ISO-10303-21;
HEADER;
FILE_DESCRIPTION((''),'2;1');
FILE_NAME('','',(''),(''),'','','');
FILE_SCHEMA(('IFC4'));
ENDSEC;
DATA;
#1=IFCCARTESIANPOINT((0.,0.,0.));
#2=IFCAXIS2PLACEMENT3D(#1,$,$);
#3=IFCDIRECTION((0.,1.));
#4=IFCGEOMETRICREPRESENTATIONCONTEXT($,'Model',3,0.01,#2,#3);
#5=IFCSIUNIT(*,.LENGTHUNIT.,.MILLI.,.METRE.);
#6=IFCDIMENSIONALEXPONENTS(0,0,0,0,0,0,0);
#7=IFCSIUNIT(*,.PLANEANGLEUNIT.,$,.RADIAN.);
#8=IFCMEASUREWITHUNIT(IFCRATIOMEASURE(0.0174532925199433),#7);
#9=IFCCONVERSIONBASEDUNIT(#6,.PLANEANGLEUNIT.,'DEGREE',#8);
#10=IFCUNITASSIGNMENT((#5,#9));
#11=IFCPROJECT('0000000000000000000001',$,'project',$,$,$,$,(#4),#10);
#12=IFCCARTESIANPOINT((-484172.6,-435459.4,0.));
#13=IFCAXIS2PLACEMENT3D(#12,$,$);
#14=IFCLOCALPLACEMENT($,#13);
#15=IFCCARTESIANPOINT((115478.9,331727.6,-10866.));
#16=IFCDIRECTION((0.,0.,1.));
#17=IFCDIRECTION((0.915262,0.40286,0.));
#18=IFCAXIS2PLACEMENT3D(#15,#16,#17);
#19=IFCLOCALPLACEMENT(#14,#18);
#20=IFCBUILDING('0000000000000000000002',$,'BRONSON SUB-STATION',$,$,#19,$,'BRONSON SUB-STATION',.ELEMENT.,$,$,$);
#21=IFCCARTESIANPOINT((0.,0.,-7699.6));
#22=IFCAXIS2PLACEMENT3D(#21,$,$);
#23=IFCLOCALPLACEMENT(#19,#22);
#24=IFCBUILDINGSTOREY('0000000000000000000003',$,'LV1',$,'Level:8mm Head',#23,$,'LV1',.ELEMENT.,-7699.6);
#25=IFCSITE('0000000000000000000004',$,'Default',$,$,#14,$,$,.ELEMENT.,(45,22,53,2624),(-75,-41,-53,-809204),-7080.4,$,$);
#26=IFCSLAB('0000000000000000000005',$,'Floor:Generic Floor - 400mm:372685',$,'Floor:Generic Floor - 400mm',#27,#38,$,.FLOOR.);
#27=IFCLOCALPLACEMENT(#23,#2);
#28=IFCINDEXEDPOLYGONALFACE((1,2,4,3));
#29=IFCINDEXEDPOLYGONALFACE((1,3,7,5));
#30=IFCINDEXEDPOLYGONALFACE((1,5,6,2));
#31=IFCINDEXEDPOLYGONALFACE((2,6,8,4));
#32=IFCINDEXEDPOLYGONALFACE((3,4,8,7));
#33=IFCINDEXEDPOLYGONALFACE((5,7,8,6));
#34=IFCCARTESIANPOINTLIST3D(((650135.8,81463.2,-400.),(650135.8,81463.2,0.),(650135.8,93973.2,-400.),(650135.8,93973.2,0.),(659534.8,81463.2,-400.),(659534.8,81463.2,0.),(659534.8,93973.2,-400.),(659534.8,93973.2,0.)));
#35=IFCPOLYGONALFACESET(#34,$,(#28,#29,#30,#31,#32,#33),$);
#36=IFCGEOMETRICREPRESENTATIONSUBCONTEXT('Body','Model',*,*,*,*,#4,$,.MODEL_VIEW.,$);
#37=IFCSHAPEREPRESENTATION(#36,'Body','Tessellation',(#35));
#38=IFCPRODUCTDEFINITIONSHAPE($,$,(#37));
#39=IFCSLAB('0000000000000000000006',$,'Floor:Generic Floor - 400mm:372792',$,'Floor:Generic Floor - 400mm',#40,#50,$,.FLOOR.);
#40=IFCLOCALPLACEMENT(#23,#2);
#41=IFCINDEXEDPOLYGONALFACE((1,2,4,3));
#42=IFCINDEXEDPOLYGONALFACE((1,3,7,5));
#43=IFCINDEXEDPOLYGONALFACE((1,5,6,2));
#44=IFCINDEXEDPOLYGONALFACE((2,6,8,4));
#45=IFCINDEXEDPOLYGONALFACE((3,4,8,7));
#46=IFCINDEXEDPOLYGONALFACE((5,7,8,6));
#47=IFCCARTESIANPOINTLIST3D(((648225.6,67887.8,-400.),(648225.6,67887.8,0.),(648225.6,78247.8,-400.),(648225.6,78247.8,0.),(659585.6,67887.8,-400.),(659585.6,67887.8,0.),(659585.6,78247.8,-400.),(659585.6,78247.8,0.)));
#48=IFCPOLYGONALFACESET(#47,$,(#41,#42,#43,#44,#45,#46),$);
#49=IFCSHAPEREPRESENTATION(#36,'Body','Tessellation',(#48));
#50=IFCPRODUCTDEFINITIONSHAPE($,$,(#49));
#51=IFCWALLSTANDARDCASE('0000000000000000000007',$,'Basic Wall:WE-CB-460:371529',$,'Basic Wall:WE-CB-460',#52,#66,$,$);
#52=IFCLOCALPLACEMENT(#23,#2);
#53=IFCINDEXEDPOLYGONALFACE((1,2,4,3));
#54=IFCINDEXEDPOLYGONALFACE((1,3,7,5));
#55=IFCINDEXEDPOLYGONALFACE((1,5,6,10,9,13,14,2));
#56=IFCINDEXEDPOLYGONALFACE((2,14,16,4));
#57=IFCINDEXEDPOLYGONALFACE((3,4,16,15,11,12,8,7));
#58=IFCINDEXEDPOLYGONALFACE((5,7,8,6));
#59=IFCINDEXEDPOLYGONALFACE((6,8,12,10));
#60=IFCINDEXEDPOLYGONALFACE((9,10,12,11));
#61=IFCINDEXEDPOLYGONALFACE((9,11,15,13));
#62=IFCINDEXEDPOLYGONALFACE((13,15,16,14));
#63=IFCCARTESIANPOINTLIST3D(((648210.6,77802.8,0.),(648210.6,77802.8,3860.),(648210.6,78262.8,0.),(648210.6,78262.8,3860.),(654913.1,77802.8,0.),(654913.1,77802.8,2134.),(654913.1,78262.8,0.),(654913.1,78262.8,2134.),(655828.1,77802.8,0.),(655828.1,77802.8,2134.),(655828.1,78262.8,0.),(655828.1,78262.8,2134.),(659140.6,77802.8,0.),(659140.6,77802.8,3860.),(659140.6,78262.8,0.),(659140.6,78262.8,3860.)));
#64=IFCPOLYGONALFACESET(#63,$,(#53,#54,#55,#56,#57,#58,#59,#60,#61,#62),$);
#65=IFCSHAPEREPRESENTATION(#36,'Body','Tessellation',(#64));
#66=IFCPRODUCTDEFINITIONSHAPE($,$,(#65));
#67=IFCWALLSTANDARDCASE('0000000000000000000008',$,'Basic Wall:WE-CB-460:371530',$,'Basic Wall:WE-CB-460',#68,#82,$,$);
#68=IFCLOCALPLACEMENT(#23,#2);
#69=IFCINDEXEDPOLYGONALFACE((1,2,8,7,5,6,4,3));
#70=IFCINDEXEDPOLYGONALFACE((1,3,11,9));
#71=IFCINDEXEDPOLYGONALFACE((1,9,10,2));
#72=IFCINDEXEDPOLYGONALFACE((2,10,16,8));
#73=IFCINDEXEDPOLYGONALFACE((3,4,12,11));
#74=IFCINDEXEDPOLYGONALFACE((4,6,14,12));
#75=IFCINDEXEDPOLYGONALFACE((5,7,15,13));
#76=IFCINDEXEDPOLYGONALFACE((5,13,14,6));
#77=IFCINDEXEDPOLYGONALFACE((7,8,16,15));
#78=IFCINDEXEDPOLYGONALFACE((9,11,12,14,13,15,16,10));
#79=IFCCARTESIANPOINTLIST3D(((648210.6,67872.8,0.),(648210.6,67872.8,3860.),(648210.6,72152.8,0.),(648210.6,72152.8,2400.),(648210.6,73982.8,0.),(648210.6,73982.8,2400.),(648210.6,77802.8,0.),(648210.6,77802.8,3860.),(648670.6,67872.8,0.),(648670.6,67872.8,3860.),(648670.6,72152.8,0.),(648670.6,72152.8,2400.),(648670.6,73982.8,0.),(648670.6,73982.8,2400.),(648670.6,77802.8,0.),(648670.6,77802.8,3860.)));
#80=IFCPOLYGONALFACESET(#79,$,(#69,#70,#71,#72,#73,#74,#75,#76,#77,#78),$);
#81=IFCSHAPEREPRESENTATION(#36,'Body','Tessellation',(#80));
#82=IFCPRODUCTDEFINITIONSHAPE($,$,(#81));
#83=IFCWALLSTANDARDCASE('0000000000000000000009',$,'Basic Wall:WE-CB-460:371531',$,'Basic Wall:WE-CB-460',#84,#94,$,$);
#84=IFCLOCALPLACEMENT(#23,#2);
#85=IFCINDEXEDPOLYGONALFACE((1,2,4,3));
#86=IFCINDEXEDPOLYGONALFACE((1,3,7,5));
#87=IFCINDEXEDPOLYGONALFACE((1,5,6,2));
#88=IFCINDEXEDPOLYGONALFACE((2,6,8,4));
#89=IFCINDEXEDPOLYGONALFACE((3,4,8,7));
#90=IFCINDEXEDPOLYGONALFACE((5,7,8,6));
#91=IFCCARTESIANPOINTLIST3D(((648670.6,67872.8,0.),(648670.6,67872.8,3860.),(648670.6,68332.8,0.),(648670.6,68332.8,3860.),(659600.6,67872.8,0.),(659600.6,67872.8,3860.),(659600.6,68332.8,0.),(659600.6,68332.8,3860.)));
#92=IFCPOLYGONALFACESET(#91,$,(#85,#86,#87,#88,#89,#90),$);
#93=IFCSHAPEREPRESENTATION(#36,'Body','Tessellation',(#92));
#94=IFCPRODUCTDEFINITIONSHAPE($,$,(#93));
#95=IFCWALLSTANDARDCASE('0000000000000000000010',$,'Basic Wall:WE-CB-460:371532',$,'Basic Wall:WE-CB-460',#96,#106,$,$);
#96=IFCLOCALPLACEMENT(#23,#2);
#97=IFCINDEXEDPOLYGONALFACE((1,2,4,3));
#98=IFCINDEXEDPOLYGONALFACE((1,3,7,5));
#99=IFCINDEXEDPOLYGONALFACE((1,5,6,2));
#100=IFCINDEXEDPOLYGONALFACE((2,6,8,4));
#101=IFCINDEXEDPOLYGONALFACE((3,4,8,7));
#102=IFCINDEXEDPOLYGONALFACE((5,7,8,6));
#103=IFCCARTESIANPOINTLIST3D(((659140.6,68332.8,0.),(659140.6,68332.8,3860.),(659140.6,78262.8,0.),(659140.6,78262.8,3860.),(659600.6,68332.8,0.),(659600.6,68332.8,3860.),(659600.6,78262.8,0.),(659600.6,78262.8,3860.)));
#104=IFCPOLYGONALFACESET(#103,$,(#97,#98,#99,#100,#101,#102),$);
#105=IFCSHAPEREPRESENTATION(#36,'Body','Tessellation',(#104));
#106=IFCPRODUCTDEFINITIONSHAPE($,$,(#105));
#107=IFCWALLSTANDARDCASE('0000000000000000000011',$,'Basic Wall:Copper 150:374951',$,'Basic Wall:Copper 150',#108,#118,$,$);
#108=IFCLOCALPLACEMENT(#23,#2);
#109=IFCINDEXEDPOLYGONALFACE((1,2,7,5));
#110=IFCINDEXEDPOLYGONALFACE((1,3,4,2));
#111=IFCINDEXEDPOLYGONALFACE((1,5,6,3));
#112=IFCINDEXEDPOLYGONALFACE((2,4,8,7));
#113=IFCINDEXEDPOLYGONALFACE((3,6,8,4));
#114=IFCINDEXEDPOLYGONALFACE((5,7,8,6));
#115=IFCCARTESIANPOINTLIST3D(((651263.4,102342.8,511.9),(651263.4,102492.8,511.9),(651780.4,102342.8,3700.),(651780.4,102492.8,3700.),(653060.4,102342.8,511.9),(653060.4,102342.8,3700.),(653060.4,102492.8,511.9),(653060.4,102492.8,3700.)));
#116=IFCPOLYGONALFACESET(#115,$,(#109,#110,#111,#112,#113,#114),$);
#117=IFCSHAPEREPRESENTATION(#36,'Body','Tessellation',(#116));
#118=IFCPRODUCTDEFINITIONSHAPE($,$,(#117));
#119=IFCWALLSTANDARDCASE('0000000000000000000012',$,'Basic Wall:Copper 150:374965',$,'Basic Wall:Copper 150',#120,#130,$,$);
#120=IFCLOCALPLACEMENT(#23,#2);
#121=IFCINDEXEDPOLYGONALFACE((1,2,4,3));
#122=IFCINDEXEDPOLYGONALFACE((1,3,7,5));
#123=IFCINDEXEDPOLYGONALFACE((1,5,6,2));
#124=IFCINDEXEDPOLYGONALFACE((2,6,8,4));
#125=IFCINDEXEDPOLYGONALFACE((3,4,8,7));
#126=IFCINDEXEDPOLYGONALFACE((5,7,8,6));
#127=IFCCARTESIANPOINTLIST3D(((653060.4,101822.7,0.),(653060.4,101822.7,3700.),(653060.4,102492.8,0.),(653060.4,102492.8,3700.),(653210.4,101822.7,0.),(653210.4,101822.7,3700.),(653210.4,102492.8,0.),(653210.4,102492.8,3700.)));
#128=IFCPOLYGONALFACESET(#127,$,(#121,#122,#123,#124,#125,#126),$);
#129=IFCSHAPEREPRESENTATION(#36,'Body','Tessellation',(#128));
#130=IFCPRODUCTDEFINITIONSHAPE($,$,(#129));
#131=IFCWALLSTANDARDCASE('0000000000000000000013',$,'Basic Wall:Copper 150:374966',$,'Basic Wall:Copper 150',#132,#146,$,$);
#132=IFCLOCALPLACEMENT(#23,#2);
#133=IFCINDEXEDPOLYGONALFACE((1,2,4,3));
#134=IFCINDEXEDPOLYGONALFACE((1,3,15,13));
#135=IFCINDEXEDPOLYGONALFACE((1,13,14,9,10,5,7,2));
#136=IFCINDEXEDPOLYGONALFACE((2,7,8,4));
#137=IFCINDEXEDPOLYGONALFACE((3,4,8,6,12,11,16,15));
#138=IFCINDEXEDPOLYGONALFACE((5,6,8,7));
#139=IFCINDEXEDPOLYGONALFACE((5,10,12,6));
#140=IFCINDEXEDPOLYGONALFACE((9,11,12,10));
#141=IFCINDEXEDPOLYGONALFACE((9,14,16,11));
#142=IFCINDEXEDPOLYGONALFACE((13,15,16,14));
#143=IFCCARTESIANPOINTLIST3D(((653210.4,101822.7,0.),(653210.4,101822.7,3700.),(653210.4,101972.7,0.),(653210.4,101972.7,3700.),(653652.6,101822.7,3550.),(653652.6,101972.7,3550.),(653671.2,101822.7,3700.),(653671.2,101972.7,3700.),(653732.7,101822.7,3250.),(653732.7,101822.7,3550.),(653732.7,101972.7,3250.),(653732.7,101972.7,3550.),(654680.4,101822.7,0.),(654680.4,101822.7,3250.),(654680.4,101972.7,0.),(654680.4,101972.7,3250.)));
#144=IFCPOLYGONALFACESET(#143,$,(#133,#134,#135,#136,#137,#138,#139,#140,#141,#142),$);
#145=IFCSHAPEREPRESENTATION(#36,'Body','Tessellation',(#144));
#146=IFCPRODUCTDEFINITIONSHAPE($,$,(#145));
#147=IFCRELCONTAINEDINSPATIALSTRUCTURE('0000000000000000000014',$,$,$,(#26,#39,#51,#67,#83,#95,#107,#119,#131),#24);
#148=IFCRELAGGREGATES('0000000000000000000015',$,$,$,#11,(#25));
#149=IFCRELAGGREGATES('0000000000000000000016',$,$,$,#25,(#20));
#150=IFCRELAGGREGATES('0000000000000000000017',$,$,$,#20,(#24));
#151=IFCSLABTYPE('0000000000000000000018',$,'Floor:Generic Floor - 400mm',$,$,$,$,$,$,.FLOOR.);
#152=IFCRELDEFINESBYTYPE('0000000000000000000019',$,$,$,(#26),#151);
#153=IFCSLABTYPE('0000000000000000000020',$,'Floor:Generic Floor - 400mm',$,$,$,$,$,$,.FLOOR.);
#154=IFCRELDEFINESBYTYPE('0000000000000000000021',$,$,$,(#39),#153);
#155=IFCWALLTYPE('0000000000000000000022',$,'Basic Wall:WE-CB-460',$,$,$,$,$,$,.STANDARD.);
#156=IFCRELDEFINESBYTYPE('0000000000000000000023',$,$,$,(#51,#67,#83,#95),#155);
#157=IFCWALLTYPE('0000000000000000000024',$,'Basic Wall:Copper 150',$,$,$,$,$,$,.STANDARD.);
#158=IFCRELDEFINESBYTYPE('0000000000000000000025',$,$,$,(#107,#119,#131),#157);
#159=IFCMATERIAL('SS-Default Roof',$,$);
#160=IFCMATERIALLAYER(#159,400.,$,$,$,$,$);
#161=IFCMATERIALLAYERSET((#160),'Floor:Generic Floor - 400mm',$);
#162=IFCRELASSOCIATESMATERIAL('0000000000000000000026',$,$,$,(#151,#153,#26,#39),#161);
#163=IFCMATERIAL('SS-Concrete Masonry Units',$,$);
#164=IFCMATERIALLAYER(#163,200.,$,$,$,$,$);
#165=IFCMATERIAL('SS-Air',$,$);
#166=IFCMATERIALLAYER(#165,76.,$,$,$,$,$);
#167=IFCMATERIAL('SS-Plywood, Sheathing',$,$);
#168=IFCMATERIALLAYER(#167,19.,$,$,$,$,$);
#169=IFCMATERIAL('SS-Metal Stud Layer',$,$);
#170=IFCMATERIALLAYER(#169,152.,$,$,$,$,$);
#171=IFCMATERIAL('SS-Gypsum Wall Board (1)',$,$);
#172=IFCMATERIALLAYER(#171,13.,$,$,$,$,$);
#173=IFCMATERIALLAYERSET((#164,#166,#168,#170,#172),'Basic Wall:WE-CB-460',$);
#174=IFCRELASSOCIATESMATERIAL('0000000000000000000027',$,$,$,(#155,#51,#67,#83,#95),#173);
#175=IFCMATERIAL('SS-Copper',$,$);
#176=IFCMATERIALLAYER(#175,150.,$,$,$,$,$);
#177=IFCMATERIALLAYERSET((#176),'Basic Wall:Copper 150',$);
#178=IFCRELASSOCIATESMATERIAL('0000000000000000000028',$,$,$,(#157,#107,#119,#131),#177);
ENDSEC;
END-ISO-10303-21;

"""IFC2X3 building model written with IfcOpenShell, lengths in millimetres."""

from ifc_helpers import new_model, entity, si_unit, converted_unit, direction, frame, frame_2d, origin, origin_2d_with_axis, place, context, subcontext, project, spatial, polyline, rectangle, outline, extrude, clip, bounded_halfspace, material, layer, layer_set, layer_usage, type_object, element, save


model = new_model("IFC2X3")

# Units and contexts
model_context = context("Model", 3, precision=0.01, world=origin(), true_north=direction((0.0, 1.0)))
body_context = subcontext(model_context, "Body", "Model", "MODEL_VIEW")
ifc_project = project(units=[si_unit("LENGTHUNIT", "METRE", prefix="MILLI"), converted_unit("PLANEANGLEUNIT", "DEGREE", entity("IfcRatioMeasure", 0.0174532925199433), si_unit("PLANEANGLEUNIT", "RADIAN"), dimensions=[0, 0, 0, 0, 0, 0, 0])], contexts=[model_context])

# Site, building, storey
site_placement = place(None, frame((-484172.6, -435459.4, 0.0)))
site = spatial("IfcSite", under=ifc_project, at=site_placement, Name="Default", CompositionType="ELEMENT", RefLatitude=(45, 22, 53, 2624), RefLongitude=(-75, -41, -53, -809204), RefElevation=-7080.4)
building_placement = place(site_placement, frame((115478.9, 331727.6, -10866.0), z_axis=(0.0, 0.0, 1.0), x_axis=(0.915262, 0.40286, 0.0)))
building = spatial("IfcBuilding", under=site, at=building_placement, Name="BRONSON SUB-STATION", LongName="BRONSON SUB-STATION", CompositionType="ELEMENT")
storey_placement = place(building_placement, frame((0.0, 0.0, -7699.6)))
storey = spatial("IfcBuildingStorey", under=building, at=storey_placement, Name="LV1", ObjectType="Level:8mm Head", LongName="LV1", CompositionType="ELEMENT", Elevation=-7699.6)

# Slabs
ifc_material_1 = material(Name="SS-Default Roof")
ifc_layer_1 = layer(ifc_material_1, 400.0)
ifc_layer_set_1 = layer_set([ifc_layer_1], Name="Floor:Generic Floor - 400mm")
ifc_layer_usage_1 = layer_usage(ifc_layer_set_1, "AXIS3", "POSITIVE", 0.0)
slab_type_1 = type_object("IfcSlabType", Name="Floor:Generic Floor - 400mm", PredefinedType="FLOOR", material=ifc_layer_set_1)
slab_1_placement = place(storey_placement, origin())
element("IfcSlab", 1, at=slab_1_placement, inside=storey, type_object=slab_type_1, material=ifc_layer_usage_1, Name="Floor:Generic Floor - 400mm:372685", ObjectType="Floor:Generic Floor - 400mm", PredefinedType="FLOOR", context=body_context, shape_type="SweptSolid", body=[
    extrude(rectangle(XDim=12510.0, YDim=9399.0, at=origin_2d_with_axis()), frame((654835.3, 87718.2, 0.0), z_axis=(0.0, 0.0, -1.0), x_axis=(0.0, 1.0, 0.0)), (0.0, 0.0, 1.0), 400.0),
])
ifc_layer_usage_2 = layer_usage(ifc_layer_set_1, "AXIS3", "POSITIVE", 0.0)
slab_type_2 = type_object("IfcSlabType", Name="Floor:Generic Floor - 400mm", PredefinedType="FLOOR", material=ifc_layer_set_1)
slab_2_placement = place(storey_placement, origin())
element("IfcSlab", 2, at=slab_2_placement, inside=storey, type_object=slab_type_2, material=ifc_layer_usage_2, Name="Floor:Generic Floor - 400mm:372792", ObjectType="Floor:Generic Floor - 400mm", PredefinedType="FLOOR", context=body_context, shape_type="SweptSolid", body=[
    extrude(rectangle(XDim=10360.0, YDim=11360.0, at=frame_2d((0.0, 0.0), x_axis=(1.0, 0.0))), frame((653905.6, 73067.8, 0.0), z_axis=(0.0, 0.0, -1.0), x_axis=(0.0, 1.0, 0.0)), (0.0, 0.0, 1.0), 400.0),
])

# Walls, openings
ifc_material_2 = material(Name="SS-Concrete Masonry Units")
ifc_layer_2 = layer(ifc_material_2, 200.0)
ifc_material_3 = material(Name="SS-Air")
ifc_layer_3 = layer(ifc_material_3, 76.0)
ifc_material_4 = material(Name="SS-Plywood, Sheathing")
ifc_layer_4 = layer(ifc_material_4, 19.0)
ifc_material_5 = material(Name="SS-Metal Stud Layer")
ifc_layer_5 = layer(ifc_material_5, 152.0)
ifc_material_6 = material(Name="SS-Gypsum Wall Board (1)")
ifc_layer_6 = layer(ifc_material_6, 13.0)
ifc_layer_set_2 = layer_set([ifc_layer_2, ifc_layer_3, ifc_layer_4, ifc_layer_5, ifc_layer_6], Name="Basic Wall:WE-CB-460")
ifc_layer_usage_3 = layer_usage(ifc_layer_set_2, "AXIS2", "NEGATIVE", 230.0)
wall_type_1 = type_object("IfcWallType", Name="Basic Wall:WE-CB-460", PredefinedType="STANDARD", material=ifc_layer_set_2)
wall_1_placement = place(storey_placement, frame((648210.6, 78032.8, 0.0)))
wall_1 = element("IfcWallStandardCase", 3, at=wall_1_placement, inside=storey, type_object=wall_type_1, material=ifc_layer_usage_3, Name="Basic Wall:WE-CB-460:371529", ObjectType="Basic Wall:WE-CB-460", context=body_context, shape_type="Clipping", body=[
    clip(extrude(rectangle(XDim=10930.0, YDim=460.0, at=frame_2d((5465.0, 0.0), x_axis=(-1.0, 0.0))), origin(), (0.0, 0.0, 1.0), 3860.0), bounded_halfspace(frame((0.0, -230.0, 3860.0)), False, frame((0.0, -230.0, 3860.0)), polyline([(0.0, 0.0), (460.0, 0.0), (10930.0, 0.0), (10930.0, 460.0), (0.0, 460.0), (0.0, 0.0)]))),
])
opening_1_placement = place(wall_1_placement, origin())
element("IfcOpeningElement", 4, at=opening_1_placement, cuts=wall_1, ObjectType="Opening", context=body_context, shape_type="SweptSolid", body=[
    extrude(rectangle(XDim=2134.0, YDim=915.0, at=frame_2d((0.0, 0.0), x_axis=(1.0, 0.0))), frame((7160.0, -1754.0, 1067.0), z_axis=(0.0, 1.0, 0.0), x_axis=(0.0, 0.0, 1.0)), (0.0, 0.0, 1.0), 3048.0),
])
ifc_layer_usage_4 = layer_usage(ifc_layer_set_2, "AXIS2", "NEGATIVE", 230.0)
wall_2_placement = place(storey_placement, frame((648440.6, 67872.8, 0.0), z_axis=(0.0, 0.0, 1.0), x_axis=(0.0, 1.0, 0.0)))
wall_2 = element("IfcWallStandardCase", 5, at=wall_2_placement, inside=storey, type_object=wall_type_1, material=ifc_layer_usage_4, Name="Basic Wall:WE-CB-460:371530", ObjectType="Basic Wall:WE-CB-460", context=body_context, shape_type="Clipping", body=[
    clip(extrude(rectangle(XDim=9930.0, YDim=460.0, at=frame_2d((4965.0, 0.0), x_axis=(-1.0, 0.0))), origin(), (0.0, 0.0, 1.0), 3860.0), bounded_halfspace(frame((0.0, -230.0, 3860.0), z_axis=(0.0, 0.0, 1.0), x_axis=(0.0, -1.0, 0.0)), False, frame((0.0, -230.0, 3860.0)), polyline([(0.0, 0.0), (460.0, 0.0), (9930.0, 0.0), (9930.0, 460.0), (0.0, 460.0), (0.0, 0.0)]))),
])
opening_2_placement = place(wall_2_placement, origin())
element("IfcOpeningElement", 6, at=opening_2_placement, cuts=wall_2, ObjectType="Opening", context=body_context, shape_type="SweptSolid", body=[
    extrude(rectangle(XDim=2400.0, YDim=1830.0, at=frame_2d((0.0, 0.0), x_axis=(1.0, 0.0))), frame((5195.0, -1754.0, 1200.0), z_axis=(0.0, 1.0, 0.0), x_axis=(0.0, 0.0, 1.0)), (0.0, 0.0, 1.0), 3048.0),
])

# Walls
ifc_layer_usage_5 = layer_usage(ifc_layer_set_2, "AXIS2", "NEGATIVE", 230.0)
wall_3_placement = place(storey_placement, frame((659600.6, 68102.8, 0.0), z_axis=(0.0, 0.0, 1.0), x_axis=(-1.0, 0.0, 0.0)))
element("IfcWallStandardCase", 7, at=wall_3_placement, inside=storey, type_object=wall_type_1, material=ifc_layer_usage_5, Name="Basic Wall:WE-CB-460:371531", ObjectType="Basic Wall:WE-CB-460", context=body_context, shape_type="Clipping", body=[
    clip(extrude(rectangle(XDim=10930.0, YDim=460.0, at=frame_2d((5465.0, 0.0), x_axis=(-1.0, 0.0))), origin(), (0.0, 0.0, 1.0), 3860.0), bounded_halfspace(frame((0.0, -230.0, 3860.0), z_axis=(0.0, 0.0, 1.0), x_axis=(-1.0, 0.0, 0.0)), False, frame((0.0, -230.0, 3860.0)), polyline([(0.0, 0.0), (460.0, 0.0), (10930.0, 0.0), (10930.0, 460.0), (0.0, 460.0), (0.0, 0.0)]))),
])
ifc_layer_usage_6 = layer_usage(ifc_layer_set_2, "AXIS2", "NEGATIVE", 230.0)
wall_4_placement = place(storey_placement, frame((659370.6, 78262.8, 0.0), z_axis=(0.0, 0.0, 1.0), x_axis=(0.0, -1.0, 0.0)))
element("IfcWallStandardCase", 8, at=wall_4_placement, inside=storey, type_object=wall_type_1, material=ifc_layer_usage_6, Name="Basic Wall:WE-CB-460:371532", ObjectType="Basic Wall:WE-CB-460", context=body_context, shape_type="Clipping", body=[
    clip(extrude(rectangle(XDim=9930.0, YDim=460.0, at=frame_2d((4965.0, 0.0), x_axis=(-1.0, 0.0))), origin(), (0.0, 0.0, 1.0), 3860.0), bounded_halfspace(frame((0.0, -230.0, 3860.0), z_axis=(0.0, 0.0, 1.0), x_axis=(0.0, 1.0, 0.0)), False, frame((0.0, -230.0, 3860.0)), polyline([(0.0, 0.0), (460.0, 0.0), (9930.0, 0.0), (9930.0, 460.0), (0.0, 460.0), (0.0, 0.0)]))),
])
ifc_material_7 = material(Name="SS-Copper")
ifc_layer_7 = layer(ifc_material_7, 150.0)
ifc_layer_set_3 = layer_set([ifc_layer_7], Name="Basic Wall:Copper 150")
ifc_layer_usage_7 = layer_usage(ifc_layer_set_3, "AXIS2", "POSITIVE", -75.0)
wall_type_2 = type_object("IfcWallType", Name="Basic Wall:Copper 150", PredefinedType="STANDARD", material=ifc_layer_set_3)
wall_5_placement = place(storey_placement, frame((651263.4, 102417.8, 511.9)))
element("IfcWallStandardCase", 9, at=wall_5_placement, inside=storey, type_object=wall_type_2, material=ifc_layer_usage_7, Name="Basic Wall:Copper 150:374951", ObjectType="Basic Wall:Copper 150", context=body_context, shape_type="Clipping", body=[
    clip(extrude(rectangle(XDim=1797.0, YDim=150.0, at=frame_2d((898.5, 0.0), x_axis=(-1.0, 0.0))), origin(), (0.0, 0.0, 1.0), 3188.1), bounded_halfspace(frame((0.0, -75.0, 0.0), z_axis=(-0.987105, 0.0, 0.160071), x_axis=(0.0, -1.0, 0.0)), False, frame((0.0, -75.0, 0.0), z_axis=(-0.987105, 0.0, 0.160071), x_axis=(0.0, -1.0, 0.0)), polyline([(0.0, 0.0), (0.0, 3229.7), (-150.0, 3229.7), (-150.0, 0.0), (0.0, 0.0)]))),
])
ifc_layer_usage_8 = layer_usage(ifc_layer_set_3, "AXIS2", "POSITIVE", -75.0)
wall_6_placement = place(storey_placement, frame((653135.4, 102492.8, 0.0), z_axis=(0.0, 0.0, 1.0), x_axis=(0.0, -1.0, 0.0)))
element("IfcWallStandardCase", 10, at=wall_6_placement, inside=storey, type_object=wall_type_2, material=ifc_layer_usage_8, Name="Basic Wall:Copper 150:374965", ObjectType="Basic Wall:Copper 150", context=body_context, shape_type="SweptSolid", body=[
    extrude(rectangle(XDim=670.2, YDim=150.0, at=frame_2d((335.1, 0.0), x_axis=(-1.0, 0.0))), origin(), (0.0, 0.0, 1.0), 3700.0),
])

# Wall, opening
ifc_layer_usage_9 = layer_usage(ifc_layer_set_3, "AXIS2", "POSITIVE", -75.0)
wall_7_placement = place(storey_placement, frame((653210.4, 101897.7, 0.0)))
wall_7 = element("IfcWallStandardCase", 11, at=wall_7_placement, inside=storey, type_object=wall_type_2, material=ifc_layer_usage_9, Name="Basic Wall:Copper 150:374966", ObjectType="Basic Wall:Copper 150", context=body_context, shape_type="Clipping", body=[
    clip(clip(extrude(rectangle(XDim=1470.0, YDim=150.0, at=frame_2d((735.0, 0.0), x_axis=(-1.0, 0.0))), origin(), (0.0, 0.0, 1.0), 3700.0), bounded_halfspace(frame((522.3, 75.0, 3250.0)), False, frame((522.3, 75.0, 3250.0)), polyline([(0.0, 0.0), (0.0, -150.0), (947.7, -150.0), (947.7, 0.0), (0.0, 0.0)]))), bounded_halfspace(frame((522.3, -75.0, 3250.0), z_axis=(-1.0, 0.0, 0.0), x_axis=(0.0, -1.0, 0.0)), True, frame((522.3, -75.0, 3250.0), z_axis=(-1.0, 0.0, 0.0), x_axis=(0.0, -1.0, 0.0)), polyline([(0.0, 0.0), (0.0, 300.0), (-150.0, 300.0), (-150.0, 0.0), (0.0, 0.0)]))),
])
opening_3_placement = place(wall_7_placement, origin())
element("IfcOpeningElement", 12, at=opening_3_placement, cuts=wall_7, ObjectType="Opening", context=body_context, shape_type="SweptSolid", body=[
    extrude(outline(polyline([(-75.0, -484.3), (75.0, -484.3), (75.0, 474.9), (-75.0, 493.6), (-75.0, -484.3)])), frame((935.7, 75.0, 3625.0), z_axis=(0.0, -1.0, 0.0), x_axis=(0.0, 0.0, 1.0)), (0.0, 0.0, 1.0), 150.0),
])

save(model, "model.ifc")
